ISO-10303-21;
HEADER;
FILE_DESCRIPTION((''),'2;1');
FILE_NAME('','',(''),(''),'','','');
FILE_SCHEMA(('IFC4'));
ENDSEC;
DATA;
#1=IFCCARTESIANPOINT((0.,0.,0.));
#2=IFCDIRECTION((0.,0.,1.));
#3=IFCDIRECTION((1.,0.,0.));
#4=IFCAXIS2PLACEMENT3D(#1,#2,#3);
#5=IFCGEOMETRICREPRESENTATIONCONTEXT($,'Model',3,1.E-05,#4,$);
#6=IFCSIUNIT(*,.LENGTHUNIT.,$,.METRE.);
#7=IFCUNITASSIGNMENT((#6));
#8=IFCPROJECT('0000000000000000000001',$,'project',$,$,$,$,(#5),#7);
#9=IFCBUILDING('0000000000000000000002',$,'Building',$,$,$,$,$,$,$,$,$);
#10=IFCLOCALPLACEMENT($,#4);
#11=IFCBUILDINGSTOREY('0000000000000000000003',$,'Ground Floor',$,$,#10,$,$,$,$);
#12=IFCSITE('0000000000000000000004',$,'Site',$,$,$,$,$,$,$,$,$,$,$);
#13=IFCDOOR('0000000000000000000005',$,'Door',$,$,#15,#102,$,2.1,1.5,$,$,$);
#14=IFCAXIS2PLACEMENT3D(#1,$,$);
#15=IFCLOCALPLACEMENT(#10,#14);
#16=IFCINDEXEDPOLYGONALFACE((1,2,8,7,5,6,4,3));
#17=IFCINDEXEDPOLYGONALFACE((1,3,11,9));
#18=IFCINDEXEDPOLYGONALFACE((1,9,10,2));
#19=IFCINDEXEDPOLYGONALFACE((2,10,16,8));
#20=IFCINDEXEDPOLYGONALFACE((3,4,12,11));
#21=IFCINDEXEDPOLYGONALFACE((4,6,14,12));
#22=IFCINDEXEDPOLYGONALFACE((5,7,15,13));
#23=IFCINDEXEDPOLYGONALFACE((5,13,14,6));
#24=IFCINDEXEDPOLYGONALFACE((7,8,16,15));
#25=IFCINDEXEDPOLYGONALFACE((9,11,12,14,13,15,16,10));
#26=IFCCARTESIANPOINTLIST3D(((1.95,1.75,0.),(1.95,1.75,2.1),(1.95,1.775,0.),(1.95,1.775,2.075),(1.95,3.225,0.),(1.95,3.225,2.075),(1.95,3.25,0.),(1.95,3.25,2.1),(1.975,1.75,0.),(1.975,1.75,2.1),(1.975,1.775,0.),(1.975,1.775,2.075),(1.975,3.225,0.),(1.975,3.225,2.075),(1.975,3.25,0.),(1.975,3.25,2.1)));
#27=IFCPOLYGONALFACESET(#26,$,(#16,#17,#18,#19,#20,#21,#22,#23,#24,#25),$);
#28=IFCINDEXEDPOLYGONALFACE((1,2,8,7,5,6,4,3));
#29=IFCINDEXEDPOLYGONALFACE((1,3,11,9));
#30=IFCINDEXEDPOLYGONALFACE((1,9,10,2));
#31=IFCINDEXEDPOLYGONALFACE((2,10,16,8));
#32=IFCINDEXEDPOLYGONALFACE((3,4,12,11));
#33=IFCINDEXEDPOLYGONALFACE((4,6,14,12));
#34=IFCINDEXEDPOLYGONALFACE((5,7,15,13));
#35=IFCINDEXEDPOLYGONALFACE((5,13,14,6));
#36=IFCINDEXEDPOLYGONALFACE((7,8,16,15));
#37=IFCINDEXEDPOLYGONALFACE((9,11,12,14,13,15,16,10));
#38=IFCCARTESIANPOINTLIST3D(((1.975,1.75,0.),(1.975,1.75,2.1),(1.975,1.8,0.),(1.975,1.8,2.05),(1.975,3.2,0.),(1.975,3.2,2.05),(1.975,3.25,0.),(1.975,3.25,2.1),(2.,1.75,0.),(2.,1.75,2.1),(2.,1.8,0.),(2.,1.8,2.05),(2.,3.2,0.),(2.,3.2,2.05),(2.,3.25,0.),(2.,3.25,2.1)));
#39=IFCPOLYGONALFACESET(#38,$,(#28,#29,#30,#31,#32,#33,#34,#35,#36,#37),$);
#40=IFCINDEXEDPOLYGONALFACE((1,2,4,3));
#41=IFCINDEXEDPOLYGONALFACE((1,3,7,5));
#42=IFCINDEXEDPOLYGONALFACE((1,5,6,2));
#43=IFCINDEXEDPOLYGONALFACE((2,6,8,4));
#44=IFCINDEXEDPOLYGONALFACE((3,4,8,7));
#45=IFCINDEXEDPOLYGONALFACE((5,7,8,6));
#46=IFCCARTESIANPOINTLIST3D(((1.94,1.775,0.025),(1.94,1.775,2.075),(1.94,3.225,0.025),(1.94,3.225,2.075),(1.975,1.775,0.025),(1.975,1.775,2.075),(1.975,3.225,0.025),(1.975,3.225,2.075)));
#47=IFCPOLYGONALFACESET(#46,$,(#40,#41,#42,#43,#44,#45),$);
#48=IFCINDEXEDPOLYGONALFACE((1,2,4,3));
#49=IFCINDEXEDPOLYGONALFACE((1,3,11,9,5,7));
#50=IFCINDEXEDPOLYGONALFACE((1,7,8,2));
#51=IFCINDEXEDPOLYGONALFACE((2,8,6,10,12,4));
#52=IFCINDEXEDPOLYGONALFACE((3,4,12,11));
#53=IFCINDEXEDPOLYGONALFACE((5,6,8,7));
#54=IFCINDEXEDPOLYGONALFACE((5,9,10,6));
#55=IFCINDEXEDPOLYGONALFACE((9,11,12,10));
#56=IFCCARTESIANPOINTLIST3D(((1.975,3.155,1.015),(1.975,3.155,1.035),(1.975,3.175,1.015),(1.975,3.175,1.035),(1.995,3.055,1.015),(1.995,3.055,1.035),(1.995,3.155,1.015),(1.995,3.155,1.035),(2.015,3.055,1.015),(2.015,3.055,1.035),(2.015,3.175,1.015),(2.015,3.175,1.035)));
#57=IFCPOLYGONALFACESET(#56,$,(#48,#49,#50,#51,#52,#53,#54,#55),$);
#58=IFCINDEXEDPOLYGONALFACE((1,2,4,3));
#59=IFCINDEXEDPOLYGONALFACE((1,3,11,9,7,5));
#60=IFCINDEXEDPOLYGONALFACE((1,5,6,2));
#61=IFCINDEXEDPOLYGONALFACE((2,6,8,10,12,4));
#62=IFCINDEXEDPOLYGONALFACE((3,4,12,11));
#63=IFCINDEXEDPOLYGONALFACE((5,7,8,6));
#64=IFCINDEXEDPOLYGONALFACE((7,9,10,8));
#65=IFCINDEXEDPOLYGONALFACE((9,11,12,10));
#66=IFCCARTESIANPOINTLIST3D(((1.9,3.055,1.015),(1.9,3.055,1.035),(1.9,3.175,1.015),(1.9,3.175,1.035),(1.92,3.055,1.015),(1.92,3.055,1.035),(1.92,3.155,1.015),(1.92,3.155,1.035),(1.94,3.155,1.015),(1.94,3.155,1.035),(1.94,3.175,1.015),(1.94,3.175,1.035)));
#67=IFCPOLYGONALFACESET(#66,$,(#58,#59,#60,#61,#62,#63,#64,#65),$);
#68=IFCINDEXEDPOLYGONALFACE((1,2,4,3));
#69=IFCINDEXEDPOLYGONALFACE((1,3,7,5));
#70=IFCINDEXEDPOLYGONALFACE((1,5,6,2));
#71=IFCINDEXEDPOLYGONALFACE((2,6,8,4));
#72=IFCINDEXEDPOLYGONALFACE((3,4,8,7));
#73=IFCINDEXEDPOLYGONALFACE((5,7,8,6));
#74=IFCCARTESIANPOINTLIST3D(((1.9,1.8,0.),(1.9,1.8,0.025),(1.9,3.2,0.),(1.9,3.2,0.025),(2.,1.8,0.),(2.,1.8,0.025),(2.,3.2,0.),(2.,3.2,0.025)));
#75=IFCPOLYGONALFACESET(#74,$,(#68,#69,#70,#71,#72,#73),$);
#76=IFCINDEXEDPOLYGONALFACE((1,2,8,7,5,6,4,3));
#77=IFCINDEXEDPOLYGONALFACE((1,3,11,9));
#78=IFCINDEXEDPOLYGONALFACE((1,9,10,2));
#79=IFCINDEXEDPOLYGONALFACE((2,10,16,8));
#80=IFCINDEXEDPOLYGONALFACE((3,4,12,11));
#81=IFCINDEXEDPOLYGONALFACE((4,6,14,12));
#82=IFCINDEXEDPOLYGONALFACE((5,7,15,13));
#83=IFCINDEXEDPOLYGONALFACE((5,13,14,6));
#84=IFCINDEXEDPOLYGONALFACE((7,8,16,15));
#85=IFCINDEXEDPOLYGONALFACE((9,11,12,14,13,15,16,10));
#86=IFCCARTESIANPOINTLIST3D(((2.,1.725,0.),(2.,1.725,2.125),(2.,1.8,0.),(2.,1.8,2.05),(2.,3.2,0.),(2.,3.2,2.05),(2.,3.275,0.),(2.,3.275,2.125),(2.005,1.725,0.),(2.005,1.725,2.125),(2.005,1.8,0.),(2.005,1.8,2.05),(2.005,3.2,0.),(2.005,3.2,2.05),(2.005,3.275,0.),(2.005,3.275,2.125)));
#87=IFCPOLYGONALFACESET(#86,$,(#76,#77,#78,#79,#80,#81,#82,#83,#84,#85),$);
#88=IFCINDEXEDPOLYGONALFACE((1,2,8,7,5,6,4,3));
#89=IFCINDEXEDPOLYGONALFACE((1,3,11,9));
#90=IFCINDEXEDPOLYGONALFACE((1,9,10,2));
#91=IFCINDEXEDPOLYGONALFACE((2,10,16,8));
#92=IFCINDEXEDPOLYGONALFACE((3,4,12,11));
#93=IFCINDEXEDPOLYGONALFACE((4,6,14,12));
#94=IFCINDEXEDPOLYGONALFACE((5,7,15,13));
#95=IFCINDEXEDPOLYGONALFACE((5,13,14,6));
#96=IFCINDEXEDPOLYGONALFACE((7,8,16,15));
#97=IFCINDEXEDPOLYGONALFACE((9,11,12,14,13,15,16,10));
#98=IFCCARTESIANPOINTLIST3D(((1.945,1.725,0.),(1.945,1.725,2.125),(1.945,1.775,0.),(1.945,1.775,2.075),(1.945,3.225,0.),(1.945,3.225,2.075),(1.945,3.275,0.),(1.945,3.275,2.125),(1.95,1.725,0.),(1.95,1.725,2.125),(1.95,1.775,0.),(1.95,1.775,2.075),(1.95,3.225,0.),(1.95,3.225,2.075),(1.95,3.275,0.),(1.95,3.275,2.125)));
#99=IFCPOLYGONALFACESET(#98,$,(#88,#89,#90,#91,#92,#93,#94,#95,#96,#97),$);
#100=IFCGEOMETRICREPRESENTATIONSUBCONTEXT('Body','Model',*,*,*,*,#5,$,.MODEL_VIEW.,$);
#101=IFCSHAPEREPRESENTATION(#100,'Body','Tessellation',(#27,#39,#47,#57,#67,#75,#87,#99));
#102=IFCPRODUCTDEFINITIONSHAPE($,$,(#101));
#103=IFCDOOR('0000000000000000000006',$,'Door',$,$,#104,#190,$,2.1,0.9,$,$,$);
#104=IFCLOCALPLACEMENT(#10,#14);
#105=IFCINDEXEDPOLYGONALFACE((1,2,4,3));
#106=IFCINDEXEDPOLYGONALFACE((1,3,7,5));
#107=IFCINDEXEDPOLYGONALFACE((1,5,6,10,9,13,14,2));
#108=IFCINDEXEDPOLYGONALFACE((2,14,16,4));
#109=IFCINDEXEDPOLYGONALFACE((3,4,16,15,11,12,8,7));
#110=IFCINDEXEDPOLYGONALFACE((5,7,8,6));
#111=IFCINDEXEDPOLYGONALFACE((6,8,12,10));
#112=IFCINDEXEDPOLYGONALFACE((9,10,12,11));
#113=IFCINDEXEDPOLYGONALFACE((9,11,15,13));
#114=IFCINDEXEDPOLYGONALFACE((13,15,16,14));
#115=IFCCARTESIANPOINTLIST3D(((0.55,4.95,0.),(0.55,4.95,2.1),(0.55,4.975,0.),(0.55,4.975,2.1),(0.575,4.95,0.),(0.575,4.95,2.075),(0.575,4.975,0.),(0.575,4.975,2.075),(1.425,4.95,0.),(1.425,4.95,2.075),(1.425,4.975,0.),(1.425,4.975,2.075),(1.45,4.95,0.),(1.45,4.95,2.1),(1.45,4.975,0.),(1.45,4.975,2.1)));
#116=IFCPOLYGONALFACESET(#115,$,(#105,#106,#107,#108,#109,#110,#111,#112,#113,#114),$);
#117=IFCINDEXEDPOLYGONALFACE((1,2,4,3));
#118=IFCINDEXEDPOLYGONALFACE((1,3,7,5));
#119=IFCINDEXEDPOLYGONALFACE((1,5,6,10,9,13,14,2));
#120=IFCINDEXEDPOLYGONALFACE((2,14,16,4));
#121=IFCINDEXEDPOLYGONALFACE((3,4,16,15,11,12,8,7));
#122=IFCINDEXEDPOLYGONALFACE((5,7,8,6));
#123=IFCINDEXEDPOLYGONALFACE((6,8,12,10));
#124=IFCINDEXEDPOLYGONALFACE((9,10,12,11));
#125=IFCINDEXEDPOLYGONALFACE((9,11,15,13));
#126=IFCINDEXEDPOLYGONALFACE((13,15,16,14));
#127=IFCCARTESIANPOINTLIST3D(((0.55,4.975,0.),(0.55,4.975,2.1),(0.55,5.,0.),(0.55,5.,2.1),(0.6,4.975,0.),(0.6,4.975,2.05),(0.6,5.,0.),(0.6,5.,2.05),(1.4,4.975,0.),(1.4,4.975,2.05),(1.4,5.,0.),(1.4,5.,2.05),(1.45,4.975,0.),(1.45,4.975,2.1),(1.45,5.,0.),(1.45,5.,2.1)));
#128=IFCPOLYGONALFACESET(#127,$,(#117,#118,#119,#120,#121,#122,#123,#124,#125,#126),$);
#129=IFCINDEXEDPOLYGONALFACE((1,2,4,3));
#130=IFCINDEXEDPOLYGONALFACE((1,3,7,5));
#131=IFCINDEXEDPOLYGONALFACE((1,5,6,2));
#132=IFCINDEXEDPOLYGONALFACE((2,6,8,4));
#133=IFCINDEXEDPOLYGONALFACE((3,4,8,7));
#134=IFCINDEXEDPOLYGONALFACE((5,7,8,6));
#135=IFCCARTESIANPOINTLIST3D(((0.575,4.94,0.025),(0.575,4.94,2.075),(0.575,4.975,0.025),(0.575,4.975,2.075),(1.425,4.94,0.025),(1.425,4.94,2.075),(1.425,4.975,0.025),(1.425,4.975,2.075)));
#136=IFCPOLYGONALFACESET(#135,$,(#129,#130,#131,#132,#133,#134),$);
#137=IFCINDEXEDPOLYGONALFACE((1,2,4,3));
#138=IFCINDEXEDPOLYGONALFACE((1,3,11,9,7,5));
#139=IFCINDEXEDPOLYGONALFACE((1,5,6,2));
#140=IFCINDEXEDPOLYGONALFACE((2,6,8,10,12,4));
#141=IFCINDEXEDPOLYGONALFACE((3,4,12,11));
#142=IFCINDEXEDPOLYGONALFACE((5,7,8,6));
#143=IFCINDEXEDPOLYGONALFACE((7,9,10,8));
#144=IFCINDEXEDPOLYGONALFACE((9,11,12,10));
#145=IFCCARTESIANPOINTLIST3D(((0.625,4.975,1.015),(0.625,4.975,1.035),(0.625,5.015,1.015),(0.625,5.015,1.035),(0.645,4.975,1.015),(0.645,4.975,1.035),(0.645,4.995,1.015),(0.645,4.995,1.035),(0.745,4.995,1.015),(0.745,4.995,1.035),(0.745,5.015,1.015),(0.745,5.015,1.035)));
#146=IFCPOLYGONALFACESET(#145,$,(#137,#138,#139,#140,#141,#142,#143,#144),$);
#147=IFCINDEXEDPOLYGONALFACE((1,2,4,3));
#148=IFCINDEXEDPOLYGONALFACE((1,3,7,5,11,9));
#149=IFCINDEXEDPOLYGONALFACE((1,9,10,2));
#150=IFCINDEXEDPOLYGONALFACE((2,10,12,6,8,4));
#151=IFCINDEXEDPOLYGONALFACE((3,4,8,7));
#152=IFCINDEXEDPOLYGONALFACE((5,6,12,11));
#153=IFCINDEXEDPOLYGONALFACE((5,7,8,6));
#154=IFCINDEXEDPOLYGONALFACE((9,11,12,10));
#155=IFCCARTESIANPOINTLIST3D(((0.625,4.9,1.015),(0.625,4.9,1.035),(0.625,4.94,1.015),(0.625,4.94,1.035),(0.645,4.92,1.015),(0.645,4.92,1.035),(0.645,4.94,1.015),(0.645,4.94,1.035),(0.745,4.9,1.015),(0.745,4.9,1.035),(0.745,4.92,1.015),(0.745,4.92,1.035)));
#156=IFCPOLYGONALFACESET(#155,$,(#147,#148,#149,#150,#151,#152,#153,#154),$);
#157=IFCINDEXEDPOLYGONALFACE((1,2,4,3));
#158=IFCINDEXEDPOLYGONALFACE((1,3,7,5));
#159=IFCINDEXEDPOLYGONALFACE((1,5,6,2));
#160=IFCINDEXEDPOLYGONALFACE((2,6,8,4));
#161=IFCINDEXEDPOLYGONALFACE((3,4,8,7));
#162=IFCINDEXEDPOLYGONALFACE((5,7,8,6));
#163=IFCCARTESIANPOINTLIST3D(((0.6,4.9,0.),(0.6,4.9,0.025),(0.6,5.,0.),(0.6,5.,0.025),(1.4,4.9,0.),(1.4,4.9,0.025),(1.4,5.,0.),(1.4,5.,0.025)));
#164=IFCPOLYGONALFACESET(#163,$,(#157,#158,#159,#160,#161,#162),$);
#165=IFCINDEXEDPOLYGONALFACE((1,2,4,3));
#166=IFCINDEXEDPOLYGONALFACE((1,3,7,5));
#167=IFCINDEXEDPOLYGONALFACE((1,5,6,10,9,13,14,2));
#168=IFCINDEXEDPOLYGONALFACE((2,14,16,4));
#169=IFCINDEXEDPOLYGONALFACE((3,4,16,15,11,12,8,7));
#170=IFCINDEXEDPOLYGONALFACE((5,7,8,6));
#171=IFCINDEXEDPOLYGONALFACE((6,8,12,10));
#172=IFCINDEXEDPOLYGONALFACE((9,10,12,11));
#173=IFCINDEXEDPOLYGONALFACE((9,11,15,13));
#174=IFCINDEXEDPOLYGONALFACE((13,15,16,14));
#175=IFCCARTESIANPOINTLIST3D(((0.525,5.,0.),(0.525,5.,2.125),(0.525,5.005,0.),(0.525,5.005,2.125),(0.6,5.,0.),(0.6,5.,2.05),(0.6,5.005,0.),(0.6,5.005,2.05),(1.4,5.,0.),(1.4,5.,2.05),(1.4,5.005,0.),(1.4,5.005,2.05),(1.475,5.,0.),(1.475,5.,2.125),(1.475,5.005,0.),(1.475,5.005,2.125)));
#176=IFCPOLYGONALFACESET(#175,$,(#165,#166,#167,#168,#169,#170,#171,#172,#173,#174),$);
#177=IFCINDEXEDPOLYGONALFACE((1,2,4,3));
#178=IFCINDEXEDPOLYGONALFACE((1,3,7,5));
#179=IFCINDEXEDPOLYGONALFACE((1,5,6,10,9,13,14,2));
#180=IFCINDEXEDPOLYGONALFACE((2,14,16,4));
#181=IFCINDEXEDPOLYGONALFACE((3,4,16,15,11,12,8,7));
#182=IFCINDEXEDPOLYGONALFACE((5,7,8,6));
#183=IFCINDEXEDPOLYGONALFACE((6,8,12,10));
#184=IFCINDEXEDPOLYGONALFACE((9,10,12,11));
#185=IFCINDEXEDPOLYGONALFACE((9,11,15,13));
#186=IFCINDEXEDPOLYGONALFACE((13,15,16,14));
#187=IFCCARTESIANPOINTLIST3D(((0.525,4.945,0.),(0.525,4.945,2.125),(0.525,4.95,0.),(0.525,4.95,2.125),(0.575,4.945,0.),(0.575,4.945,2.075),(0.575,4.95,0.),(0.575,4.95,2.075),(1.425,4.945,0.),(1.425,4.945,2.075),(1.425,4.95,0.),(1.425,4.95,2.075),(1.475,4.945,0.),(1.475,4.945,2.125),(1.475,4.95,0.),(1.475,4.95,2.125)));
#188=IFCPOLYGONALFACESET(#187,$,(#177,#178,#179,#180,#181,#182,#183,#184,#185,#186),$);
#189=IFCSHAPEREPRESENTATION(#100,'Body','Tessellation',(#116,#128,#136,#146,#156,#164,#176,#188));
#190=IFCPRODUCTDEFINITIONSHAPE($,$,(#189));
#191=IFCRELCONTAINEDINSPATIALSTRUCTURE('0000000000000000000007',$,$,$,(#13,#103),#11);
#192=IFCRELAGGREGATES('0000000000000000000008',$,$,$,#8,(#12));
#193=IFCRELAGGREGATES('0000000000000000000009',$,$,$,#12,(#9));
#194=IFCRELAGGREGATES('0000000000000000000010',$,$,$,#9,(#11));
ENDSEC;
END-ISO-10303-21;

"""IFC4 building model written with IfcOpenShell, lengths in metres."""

from ifc_helpers import new_model, si_unit, frame, origin_with_axes, place, context, subcontext, project, spatial, line, indexed_curve, outline, extrude, element, save


model = new_model("IFC4")

# Units and contexts
model_context = context("Model", 3, precision=1e-05, world=origin_with_axes())
body_context = subcontext(model_context, "Body", "Model", "MODEL_VIEW")
ifc_project = project(units=[si_unit("LENGTHUNIT", "METRE")], contexts=[model_context])

# Site, building, storey
site = spatial("IfcSite", under=ifc_project, Name="Site")
building = spatial("IfcBuilding", under=site, Name="Building")
storey_placement = place(None, origin_with_axes())
storey = spatial("IfcBuildingStorey", under=building, at=storey_placement, Name="Ground Floor")

# Doors
door_1_placement = place(storey_placement, frame((2.0, 1.75, 0.0), z_axis=(0.0, 0.0, 1.0), x_axis=(0.0, 1.0, 0.0)))
element("IfcDoor", 1, at=door_1_placement, inside=storey, Name="Door", OverallHeight=2.1, OverallWidth=1.5, context=body_context, shape_type="SweptSolid", body=[
    extrude(outline(indexed_curve([(0.0, 0.0), (0.0, 2.1), (1.5, 2.1), (1.5, 0.0), (1.475, 0.0), (1.475, 2.075), (0.025, 2.075), (0.025, 0.0)], segments=[line(1, 2, 3, 4, 5, 6, 7, 8, 1)])), frame((0.0, 0.025, 0.0), z_axis=(0.0, -1.0, 0.0), x_axis=(1.0, 0.0, 0.0)), (0.0, 0.0, -1.0), 0.025),
    extrude(outline(indexed_curve([(0.0, 0.0), (0.0, 2.1), (1.5, 2.1), (1.5, 0.0), (1.45, 0.0), (1.45, 2.05), (0.05, 2.05), (0.05, 0.0)], segments=[line(1, 2, 3, 4, 5, 6, 7, 8, 1)])), frame((0.0, 0.0, 0.0), z_axis=(0.0, -1.0, 0.0), x_axis=(1.0, 0.0, 0.0)), (0.0, 0.0, -1.0), 0.025),
    extrude(outline(indexed_curve([(0.0, 0.0), (1.45, 0.0), (1.45, 0.035), (0.0, 0.035)], segments=[line(1, 2, 3, 4, 1)])), frame((0.025, 0.025, 0.025), z_axis=(0.0, 0.0, 1.0), x_axis=(1.0, 0.0, 0.0)), (0.0, 0.0, 1.0), 2.05),
    extrude(outline(indexed_curve([(0.0, 0.0), (0.0, -0.04), (-0.12, -0.04), (-0.12, -0.02), (-0.02, -0.02), (-0.02, 0.0)], segments=[line(1, 2, 3, 4, 5, 6, 1)])), frame((1.425, 0.025, 1.015), z_axis=(0.0, 0.0, 1.0), x_axis=(1.0, 0.0, 0.0)), (0.0, 0.0, 1.0), 0.02),
    extrude(outline(indexed_curve([(0.0, 0.0), (0.0, 0.04), (-0.12, 0.04), (-0.12, 0.02), (-0.02, 0.02), (-0.02, 0.0)], segments=[line(1, 2, 3, 4, 5, 6, 1)])), frame((1.425, 0.06, 1.015), z_axis=(0.0, 0.0, 1.0), x_axis=(1.0, 0.0, 0.0)), (0.0, 0.0, 1.0), 0.02),
    extrude(outline(indexed_curve([(0.0, 0.0), (1.4, 0.0), (1.4, 0.1), (0.0, 0.1)], segments=[line(1, 2, 3, 4, 1)])), frame((0.05, 0.0, 0.0), z_axis=(0.0, 0.0, 1.0), x_axis=(1.0, 0.0, 0.0)), (0.0, 0.0, 1.0), 0.025),
    extrude(outline(indexed_curve([(0.0, 0.0), (0.0, 2.125), (1.55, 2.125), (1.55, 0.0), (1.475, 0.0), (1.475, 2.05), (0.075, 2.05), (0.075, 0.0)], segments=[line(1, 2, 3, 4, 5, 6, 7, 8, 1)])), frame((-0.025, -0.005, 0.0), z_axis=(0.0, -1.0, 0.0), x_axis=(1.0, 0.0, 0.0)), (0.0, 0.0, -1.0), 0.005),
    extrude(outline(indexed_curve([(0.0, 0.0), (0.0, 2.125), (1.55, 2.125), (1.55, 0.0), (1.5, 0.0), (1.5, 2.075), (0.05, 2.075), (0.05, 0.0)], segments=[line(1, 2, 3, 4, 5, 6, 7, 8, 1)])), frame((-0.025, 0.05, 0.0), z_axis=(0.0, -1.0, 0.0), x_axis=(1.0, 0.0, 0.0)), (0.0, 0.0, -1.0), 0.005),
])
door_2_placement = place(storey_placement, frame((1.45, 5.0, 0.0), z_axis=(0.0, 0.0, 1.0), x_axis=(-1.0, 0.0, 0.0)))
element("IfcDoor", 2, at=door_2_placement, inside=storey, Name="Door", OverallHeight=2.1, OverallWidth=0.9, context=body_context, shape_type="SweptSolid", body=[
    extrude(outline(indexed_curve([(0.0, 0.0), (0.0, 2.1), (0.9, 2.1), (0.9, 0.0), (0.875, 0.0), (0.875, 2.075), (0.025, 2.075), (0.025, 0.0)], segments=[line(1, 2, 3, 4, 5, 6, 7, 8, 1)])), frame((0.0, 0.025, 0.0), z_axis=(0.0, -1.0, 0.0), x_axis=(1.0, 0.0, 0.0)), (0.0, 0.0, -1.0), 0.025),
    extrude(outline(indexed_curve([(0.0, 0.0), (0.0, 2.1), (0.9, 2.1), (0.9, 0.0), (0.85, 0.0), (0.85, 2.05), (0.05, 2.05), (0.05, 0.0)], segments=[line(1, 2, 3, 4, 5, 6, 7, 8, 1)])), frame((0.0, 0.0, 0.0), z_axis=(0.0, -1.0, 0.0), x_axis=(1.0, 0.0, 0.0)), (0.0, 0.0, -1.0), 0.025),
    extrude(outline(indexed_curve([(0.0, 0.0), (0.85, 0.0), (0.85, 0.035), (0.0, 0.035)], segments=[line(1, 2, 3, 4, 1)])), frame((0.025, 0.025, 0.025), z_axis=(0.0, 0.0, 1.0), x_axis=(1.0, 0.0, 0.0)), (0.0, 0.0, 1.0), 2.05),
    extrude(outline(indexed_curve([(0.0, 0.0), (0.0, -0.04), (-0.12, -0.04), (-0.12, -0.02), (-0.02, -0.02), (-0.02, 0.0)], segments=[line(1, 2, 3, 4, 5, 6, 1)])), frame((0.825, 0.025, 1.015), z_axis=(0.0, 0.0, 1.0), x_axis=(1.0, 0.0, 0.0)), (0.0, 0.0, 1.0), 0.02),
    extrude(outline(indexed_curve([(0.0, 0.0), (0.0, 0.04), (-0.12, 0.04), (-0.12, 0.02), (-0.02, 0.02), (-0.02, 0.0)], segments=[line(1, 2, 3, 4, 5, 6, 1)])), frame((0.825, 0.06, 1.015), z_axis=(0.0, 0.0, 1.0), x_axis=(1.0, 0.0, 0.0)), (0.0, 0.0, 1.0), 0.02),
    extrude(outline(indexed_curve([(0.0, 0.0), (0.8, 0.0), (0.8, 0.1), (0.0, 0.1)], segments=[line(1, 2, 3, 4, 1)])), frame((0.05, 0.0, 0.0), z_axis=(0.0, 0.0, 1.0), x_axis=(1.0, 0.0, 0.0)), (0.0, 0.0, 1.0), 0.025),
    extrude(outline(indexed_curve([(0.0, 0.0), (0.0, 2.125), (0.95, 2.125), (0.95, 0.0), (0.875, 0.0), (0.875, 2.05), (0.075, 2.05), (0.075, 0.0)], segments=[line(1, 2, 3, 4, 5, 6, 7, 8, 1)])), frame((-0.025, -0.005, 0.0), z_axis=(0.0, -1.0, 0.0), x_axis=(1.0, 0.0, 0.0)), (0.0, 0.0, -1.0), 0.005),
    extrude(outline(indexed_curve([(0.0, 0.0), (0.0, 2.125), (0.95, 2.125), (0.95, 0.0), (0.9, 0.0), (0.9, 2.075), (0.05, 2.075), (0.05, 0.0)], segments=[line(1, 2, 3, 4, 5, 6, 7, 8, 1)])), frame((-0.025, 0.05, 0.0), z_axis=(0.0, -1.0, 0.0), x_axis=(1.0, 0.0, 0.0)), (0.0, 0.0, -1.0), 0.005),
])

save(model, "model.ifc")
